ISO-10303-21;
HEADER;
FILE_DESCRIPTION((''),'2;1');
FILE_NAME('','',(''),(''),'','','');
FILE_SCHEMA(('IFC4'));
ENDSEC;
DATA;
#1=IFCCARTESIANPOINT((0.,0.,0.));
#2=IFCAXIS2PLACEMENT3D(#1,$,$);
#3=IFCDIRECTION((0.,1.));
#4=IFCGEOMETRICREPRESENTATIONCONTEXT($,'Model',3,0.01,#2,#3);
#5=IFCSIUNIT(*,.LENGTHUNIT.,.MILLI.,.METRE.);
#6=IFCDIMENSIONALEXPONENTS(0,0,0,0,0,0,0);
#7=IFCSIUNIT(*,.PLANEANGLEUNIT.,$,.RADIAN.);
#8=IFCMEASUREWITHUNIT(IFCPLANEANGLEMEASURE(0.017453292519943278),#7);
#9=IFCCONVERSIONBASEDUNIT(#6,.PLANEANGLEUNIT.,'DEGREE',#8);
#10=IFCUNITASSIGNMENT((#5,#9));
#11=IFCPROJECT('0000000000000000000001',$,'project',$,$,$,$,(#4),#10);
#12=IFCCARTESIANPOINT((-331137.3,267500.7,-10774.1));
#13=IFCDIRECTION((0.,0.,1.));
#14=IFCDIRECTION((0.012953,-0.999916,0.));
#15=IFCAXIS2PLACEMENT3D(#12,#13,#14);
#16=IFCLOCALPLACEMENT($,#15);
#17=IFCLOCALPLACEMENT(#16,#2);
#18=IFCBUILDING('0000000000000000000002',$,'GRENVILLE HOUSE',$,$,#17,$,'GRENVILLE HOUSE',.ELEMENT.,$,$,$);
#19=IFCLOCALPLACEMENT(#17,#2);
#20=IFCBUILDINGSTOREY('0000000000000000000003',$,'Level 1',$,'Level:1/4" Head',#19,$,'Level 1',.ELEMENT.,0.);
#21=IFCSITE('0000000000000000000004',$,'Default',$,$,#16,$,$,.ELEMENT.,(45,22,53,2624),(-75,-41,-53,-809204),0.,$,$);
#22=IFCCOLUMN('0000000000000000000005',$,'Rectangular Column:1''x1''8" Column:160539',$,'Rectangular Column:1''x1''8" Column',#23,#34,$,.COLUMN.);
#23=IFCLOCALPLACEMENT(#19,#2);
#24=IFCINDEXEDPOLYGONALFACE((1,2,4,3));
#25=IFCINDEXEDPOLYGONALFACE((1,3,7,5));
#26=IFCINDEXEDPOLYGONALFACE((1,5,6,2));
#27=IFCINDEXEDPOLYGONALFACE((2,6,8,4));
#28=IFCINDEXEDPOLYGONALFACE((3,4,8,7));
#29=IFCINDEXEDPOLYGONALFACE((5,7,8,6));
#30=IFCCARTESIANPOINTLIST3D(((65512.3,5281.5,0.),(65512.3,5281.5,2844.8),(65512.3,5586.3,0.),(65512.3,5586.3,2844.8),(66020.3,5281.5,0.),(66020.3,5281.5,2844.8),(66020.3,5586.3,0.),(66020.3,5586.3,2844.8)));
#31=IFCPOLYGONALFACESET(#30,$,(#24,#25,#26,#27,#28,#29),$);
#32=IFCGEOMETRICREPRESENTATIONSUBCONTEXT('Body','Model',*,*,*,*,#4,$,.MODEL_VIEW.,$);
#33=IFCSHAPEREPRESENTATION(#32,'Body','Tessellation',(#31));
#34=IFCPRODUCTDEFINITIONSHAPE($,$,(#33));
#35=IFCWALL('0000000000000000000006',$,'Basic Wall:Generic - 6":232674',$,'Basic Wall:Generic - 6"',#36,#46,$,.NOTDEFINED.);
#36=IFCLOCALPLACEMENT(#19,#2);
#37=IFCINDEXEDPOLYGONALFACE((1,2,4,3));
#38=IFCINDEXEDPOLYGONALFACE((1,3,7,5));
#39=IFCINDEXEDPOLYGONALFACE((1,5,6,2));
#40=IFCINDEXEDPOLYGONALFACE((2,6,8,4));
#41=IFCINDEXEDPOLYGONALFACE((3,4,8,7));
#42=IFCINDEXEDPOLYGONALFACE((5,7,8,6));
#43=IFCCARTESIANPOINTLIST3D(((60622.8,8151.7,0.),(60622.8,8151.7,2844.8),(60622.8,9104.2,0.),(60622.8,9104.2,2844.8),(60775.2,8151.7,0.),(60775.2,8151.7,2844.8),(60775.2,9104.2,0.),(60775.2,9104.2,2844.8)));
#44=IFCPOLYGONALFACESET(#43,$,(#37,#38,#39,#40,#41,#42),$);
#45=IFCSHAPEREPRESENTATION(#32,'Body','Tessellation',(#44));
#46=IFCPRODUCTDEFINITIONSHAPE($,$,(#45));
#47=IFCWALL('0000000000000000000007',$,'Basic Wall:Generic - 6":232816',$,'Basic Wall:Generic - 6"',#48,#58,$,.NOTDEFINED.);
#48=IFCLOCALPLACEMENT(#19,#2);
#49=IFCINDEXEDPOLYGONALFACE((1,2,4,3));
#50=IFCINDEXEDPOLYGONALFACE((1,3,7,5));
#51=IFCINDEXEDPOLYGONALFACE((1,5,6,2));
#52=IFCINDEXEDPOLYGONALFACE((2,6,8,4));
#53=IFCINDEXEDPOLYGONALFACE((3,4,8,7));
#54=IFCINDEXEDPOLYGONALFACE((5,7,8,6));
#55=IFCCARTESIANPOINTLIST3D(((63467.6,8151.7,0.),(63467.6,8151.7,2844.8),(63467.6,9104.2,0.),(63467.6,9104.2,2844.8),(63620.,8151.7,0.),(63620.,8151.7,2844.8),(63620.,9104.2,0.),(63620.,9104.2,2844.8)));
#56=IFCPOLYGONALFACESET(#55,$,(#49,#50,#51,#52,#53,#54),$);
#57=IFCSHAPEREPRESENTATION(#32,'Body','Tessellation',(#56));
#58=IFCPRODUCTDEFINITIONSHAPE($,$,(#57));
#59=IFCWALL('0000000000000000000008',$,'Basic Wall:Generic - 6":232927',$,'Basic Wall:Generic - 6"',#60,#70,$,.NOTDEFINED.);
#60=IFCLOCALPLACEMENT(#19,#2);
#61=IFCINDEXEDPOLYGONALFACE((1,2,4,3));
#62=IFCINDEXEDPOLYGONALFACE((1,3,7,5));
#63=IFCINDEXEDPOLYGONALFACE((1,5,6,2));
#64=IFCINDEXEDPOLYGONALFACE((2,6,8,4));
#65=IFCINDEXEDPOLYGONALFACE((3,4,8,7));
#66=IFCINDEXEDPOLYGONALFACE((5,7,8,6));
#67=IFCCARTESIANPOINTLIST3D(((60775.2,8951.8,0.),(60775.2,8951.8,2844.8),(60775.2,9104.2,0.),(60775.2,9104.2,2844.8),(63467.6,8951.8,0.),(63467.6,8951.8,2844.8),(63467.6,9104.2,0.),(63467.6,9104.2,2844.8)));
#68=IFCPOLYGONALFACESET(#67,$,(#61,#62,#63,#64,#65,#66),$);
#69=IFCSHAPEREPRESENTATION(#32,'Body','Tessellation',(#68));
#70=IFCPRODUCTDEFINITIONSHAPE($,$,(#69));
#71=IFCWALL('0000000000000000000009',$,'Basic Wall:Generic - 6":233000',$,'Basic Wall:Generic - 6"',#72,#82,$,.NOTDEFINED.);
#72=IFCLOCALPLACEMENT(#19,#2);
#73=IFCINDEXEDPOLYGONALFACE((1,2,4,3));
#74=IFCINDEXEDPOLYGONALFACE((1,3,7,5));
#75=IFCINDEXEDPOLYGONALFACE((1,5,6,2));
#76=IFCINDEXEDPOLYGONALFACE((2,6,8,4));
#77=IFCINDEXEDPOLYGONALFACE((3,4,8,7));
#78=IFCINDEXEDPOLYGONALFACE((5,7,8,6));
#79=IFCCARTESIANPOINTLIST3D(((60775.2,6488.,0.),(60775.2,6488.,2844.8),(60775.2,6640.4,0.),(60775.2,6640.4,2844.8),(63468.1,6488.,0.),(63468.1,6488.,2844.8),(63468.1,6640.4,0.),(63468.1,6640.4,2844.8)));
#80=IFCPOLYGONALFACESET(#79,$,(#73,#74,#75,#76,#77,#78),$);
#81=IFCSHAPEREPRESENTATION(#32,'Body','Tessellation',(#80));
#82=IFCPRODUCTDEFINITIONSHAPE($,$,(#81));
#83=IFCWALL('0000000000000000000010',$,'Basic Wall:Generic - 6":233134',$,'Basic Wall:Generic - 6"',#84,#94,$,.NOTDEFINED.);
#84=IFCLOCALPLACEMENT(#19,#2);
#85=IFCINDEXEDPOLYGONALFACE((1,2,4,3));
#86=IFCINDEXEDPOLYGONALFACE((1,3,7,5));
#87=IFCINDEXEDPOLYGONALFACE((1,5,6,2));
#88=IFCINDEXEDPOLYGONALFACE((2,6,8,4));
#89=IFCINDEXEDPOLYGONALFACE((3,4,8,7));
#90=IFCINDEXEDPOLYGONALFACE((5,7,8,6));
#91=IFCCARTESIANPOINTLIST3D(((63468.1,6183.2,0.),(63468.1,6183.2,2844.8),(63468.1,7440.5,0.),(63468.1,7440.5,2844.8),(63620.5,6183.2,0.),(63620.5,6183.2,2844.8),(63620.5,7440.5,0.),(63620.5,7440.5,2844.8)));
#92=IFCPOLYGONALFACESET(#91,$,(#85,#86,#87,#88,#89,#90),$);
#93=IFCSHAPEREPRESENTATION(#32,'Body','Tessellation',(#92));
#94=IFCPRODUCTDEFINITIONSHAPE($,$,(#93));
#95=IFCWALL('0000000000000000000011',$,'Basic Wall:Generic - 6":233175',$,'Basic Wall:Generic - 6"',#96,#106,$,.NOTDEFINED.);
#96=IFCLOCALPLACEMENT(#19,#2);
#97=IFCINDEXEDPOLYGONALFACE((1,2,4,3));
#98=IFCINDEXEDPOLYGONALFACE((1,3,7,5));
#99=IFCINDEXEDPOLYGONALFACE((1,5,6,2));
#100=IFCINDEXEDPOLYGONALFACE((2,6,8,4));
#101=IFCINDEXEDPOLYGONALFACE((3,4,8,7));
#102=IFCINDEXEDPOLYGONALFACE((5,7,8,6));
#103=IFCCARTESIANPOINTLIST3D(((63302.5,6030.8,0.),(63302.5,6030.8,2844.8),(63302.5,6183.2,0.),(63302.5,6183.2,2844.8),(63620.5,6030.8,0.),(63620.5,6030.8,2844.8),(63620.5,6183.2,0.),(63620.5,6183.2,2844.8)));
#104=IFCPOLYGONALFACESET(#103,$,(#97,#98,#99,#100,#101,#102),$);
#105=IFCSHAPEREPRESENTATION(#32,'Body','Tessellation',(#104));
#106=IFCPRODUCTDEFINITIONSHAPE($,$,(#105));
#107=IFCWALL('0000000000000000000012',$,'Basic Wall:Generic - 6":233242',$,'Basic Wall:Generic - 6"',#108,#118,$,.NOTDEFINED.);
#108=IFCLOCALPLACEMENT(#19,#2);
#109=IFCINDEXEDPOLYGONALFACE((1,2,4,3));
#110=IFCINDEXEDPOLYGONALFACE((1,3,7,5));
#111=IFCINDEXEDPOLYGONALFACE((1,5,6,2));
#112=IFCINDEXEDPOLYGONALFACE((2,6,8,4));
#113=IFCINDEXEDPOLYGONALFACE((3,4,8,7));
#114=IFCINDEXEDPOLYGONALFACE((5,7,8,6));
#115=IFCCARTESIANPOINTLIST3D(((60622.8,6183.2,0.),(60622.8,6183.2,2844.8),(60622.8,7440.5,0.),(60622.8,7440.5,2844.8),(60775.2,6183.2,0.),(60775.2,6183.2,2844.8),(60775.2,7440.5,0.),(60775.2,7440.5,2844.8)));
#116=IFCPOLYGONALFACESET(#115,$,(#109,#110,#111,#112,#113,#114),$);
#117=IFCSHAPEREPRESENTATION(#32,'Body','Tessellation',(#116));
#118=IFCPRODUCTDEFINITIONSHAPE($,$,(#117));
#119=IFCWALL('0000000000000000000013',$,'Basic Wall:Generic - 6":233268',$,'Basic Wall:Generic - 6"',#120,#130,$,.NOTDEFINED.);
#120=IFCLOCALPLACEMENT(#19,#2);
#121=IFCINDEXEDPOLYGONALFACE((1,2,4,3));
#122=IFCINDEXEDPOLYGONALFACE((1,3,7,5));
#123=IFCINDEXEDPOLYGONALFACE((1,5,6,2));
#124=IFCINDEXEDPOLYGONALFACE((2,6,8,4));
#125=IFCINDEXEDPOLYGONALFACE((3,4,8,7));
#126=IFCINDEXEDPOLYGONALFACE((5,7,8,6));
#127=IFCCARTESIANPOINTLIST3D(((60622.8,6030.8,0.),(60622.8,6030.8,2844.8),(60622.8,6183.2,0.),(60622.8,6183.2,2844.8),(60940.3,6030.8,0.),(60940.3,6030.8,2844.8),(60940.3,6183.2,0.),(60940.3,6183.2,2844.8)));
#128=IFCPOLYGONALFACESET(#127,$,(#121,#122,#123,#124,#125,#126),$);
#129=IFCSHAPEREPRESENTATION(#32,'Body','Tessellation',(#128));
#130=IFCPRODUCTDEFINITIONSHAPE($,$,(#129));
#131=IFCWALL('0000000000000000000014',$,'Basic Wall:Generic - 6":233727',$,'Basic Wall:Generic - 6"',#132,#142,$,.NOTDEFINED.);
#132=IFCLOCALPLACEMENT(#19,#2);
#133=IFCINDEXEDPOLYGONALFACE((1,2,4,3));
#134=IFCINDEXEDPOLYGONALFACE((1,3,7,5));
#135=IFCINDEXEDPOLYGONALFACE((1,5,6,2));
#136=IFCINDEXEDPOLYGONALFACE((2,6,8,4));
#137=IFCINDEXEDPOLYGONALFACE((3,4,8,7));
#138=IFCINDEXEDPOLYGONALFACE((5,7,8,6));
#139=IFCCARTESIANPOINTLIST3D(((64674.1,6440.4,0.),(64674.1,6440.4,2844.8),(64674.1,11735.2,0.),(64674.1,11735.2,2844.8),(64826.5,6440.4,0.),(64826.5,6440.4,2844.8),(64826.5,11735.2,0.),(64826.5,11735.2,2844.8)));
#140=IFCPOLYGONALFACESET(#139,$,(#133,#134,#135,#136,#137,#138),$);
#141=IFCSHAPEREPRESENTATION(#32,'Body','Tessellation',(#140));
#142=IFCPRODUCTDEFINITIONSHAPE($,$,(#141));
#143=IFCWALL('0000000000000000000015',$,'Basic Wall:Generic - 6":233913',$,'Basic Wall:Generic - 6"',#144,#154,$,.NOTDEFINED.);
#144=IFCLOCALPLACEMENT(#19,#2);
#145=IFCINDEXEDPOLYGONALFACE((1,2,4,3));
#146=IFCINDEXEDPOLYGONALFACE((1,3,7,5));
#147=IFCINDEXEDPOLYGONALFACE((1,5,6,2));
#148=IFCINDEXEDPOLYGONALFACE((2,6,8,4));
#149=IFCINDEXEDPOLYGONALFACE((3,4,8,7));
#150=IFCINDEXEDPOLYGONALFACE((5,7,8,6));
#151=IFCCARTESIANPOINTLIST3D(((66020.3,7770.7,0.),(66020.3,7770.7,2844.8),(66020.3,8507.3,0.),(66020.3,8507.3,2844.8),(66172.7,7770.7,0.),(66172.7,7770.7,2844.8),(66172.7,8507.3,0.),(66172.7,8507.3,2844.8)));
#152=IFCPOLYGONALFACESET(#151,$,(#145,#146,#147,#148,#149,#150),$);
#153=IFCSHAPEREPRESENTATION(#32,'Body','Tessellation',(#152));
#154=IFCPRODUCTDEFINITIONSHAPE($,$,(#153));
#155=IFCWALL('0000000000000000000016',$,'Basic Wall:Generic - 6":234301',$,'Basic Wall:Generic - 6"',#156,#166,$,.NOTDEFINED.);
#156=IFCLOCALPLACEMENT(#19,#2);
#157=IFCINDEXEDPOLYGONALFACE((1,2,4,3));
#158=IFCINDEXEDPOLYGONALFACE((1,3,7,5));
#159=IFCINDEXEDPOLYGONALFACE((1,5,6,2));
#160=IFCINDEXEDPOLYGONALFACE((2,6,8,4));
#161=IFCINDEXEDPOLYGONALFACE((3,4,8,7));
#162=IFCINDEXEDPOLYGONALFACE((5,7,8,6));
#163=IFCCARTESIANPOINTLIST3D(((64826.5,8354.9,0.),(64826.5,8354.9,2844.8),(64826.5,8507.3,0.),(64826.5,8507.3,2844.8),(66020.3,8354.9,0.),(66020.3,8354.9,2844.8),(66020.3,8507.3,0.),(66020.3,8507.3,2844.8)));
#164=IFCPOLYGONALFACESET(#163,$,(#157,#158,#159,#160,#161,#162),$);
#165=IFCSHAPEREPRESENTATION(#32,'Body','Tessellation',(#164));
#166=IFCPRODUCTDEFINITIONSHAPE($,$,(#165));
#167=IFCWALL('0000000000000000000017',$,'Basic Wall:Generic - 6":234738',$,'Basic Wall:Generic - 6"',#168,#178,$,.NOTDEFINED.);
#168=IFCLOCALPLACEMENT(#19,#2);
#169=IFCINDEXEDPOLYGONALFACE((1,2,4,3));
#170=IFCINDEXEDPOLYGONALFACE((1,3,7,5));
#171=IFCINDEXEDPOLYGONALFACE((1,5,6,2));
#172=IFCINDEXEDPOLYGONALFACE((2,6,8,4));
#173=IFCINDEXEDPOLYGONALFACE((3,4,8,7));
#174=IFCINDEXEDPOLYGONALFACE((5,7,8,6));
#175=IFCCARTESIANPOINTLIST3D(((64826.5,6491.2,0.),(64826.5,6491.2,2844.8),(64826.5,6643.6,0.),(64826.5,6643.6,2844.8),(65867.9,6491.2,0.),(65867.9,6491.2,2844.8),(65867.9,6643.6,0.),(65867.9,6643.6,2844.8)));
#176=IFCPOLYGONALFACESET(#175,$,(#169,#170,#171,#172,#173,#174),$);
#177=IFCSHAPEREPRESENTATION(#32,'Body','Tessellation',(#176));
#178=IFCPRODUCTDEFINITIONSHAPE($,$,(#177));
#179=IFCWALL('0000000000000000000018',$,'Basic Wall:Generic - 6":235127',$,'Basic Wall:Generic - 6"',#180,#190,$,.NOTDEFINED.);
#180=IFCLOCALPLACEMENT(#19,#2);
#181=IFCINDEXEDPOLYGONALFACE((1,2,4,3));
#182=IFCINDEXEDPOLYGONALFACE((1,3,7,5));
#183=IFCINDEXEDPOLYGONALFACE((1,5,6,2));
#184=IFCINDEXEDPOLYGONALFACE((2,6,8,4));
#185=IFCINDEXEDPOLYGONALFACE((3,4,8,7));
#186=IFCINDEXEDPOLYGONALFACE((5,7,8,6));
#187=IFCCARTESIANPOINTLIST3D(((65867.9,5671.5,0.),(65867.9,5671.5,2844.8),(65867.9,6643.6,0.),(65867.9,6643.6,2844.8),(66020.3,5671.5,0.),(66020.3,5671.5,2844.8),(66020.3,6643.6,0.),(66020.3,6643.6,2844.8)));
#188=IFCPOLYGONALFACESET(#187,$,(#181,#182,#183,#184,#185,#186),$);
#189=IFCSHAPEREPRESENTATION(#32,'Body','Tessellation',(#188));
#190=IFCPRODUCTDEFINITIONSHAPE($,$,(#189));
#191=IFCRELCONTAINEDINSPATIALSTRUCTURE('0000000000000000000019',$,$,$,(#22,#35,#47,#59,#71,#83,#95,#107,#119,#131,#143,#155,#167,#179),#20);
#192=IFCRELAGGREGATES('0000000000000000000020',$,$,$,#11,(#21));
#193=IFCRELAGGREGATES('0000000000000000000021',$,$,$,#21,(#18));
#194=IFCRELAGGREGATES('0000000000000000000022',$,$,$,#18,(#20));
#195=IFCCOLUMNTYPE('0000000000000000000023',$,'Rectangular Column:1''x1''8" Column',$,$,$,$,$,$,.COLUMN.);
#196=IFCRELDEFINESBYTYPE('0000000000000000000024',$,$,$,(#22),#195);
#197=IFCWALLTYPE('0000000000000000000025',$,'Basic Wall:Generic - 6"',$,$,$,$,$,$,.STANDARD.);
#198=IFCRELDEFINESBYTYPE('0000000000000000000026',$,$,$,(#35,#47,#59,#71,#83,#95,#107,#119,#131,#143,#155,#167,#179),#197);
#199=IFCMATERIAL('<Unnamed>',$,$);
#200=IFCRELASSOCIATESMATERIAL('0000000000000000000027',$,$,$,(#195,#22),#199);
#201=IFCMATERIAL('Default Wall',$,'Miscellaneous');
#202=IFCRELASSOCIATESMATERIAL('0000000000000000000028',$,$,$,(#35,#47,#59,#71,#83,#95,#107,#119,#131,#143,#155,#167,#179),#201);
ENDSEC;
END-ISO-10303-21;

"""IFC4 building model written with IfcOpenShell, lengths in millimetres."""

from ifc_helpers import new_model, entity, si_unit, converted_unit, direction, frame, origin, place, context, subcontext, project, spatial, indexed_curve, outline, extrude, source, transform, mapped, material, type_object, type_shapes, element, save


model = new_model("IFC4")

# Units and contexts
model_context = context("Model", 3, precision=0.01, world=origin(), true_north=direction((0.0, 1.0)))
body_context = subcontext(model_context, "Body", "Model", "MODEL_VIEW")
ifc_project = project(units=[si_unit("LENGTHUNIT", "METRE", prefix="MILLI"), converted_unit("PLANEANGLEUNIT", "DEGREE", entity("IfcPlaneAngleMeasure", 0.017453292519943278), si_unit("PLANEANGLEUNIT", "RADIAN"), dimensions=[0, 0, 0, 0, 0, 0, 0])], contexts=[model_context])

# Site, building, storey
site_placement = place(None, frame((-331137.3, 267500.7, -10774.1), z_axis=(0.0, 0.0, 1.0), x_axis=(0.012953, -0.999916, 0.0)))
site = spatial("IfcSite", under=ifc_project, at=site_placement, Name="Default", CompositionType="ELEMENT", RefLatitude=(45, 22, 53, 2624), RefLongitude=(-75, -41, -53, -809204), RefElevation=0.0)
building_placement = place(site_placement, origin())
building = spatial("IfcBuilding", under=site, at=building_placement, Name="GRENVILLE HOUSE", LongName="GRENVILLE HOUSE", CompositionType="ELEMENT")
storey_placement = place(building_placement, origin())
storey = spatial("IfcBuildingStorey", under=building, at=storey_placement, Name="Level 1", ObjectType="Level:1/4\" Head", LongName="Level 1", CompositionType="ELEMENT", Elevation=0.0)

# Column
ifc_material_1 = material(Name="<Unnamed>")
column_type = type_object("IfcColumnType", Name="Rectangular Column:1'x1'8\" Column", PredefinedType="COLUMN", material=ifc_material_1)
shared_shape = source(origin(), body_context, "Body", "SweptSolid", [
    extrude(outline(indexed_curve([(-254.0, -152.4), (254.0, -152.4), (254.0, 152.4), (-254.0, 152.4), (-254.0, -152.4)], self_intersect=False)), frame((0.0, 0.0, 0.0), z_axis=(0.0, 0.0, 1.0), x_axis=(-1.0, 0.0, 0.0)), (0.0, 0.0, 1.0), 2844.8),
])
type_shapes(column_type, [shared_shape])
column_placement = place(storey_placement, frame((65766.3, 5433.9, 0.0)))
element("IfcColumn", 1, at=column_placement, inside=storey, type_object=column_type, material=ifc_material_1, Name="Rectangular Column:1'x1'8\" Column:160539", ObjectType="Rectangular Column:1'x1'8\" Column", PredefinedType="COLUMN", context=body_context, shape_type="MappedRepresentation", body=[
    mapped(shared_shape, transform((0.0, 0.0, 0.0), scale=1.0)),
])

# Walls
ifc_material_2 = material(Name="Default Wall", Category="Miscellaneous")
wall_type = type_object("IfcWallType", Name="Basic Wall:Generic - 6\"", PredefinedType="STANDARD")
wall_1_placement = place(storey_placement, frame((60699.0, 8151.7, 0.0), z_axis=(0.0, 0.0, 1.0), x_axis=(0.0, 1.0, 0.0)))
element("IfcWall", 2, at=wall_1_placement, inside=storey, type_object=wall_type, material=ifc_material_2, Name="Basic Wall:Generic - 6\":232674", ObjectType="Basic Wall:Generic - 6\"", PredefinedType="NOTDEFINED", context=body_context, shape_type="SweptSolid", body=[
    extrude(outline(indexed_curve([(952.5, 76.2), (0.0, 76.2), (0.0, -76.2), (952.5, -76.2), (952.5, 76.2)], self_intersect=False)), origin(), (0.0, 0.0, 1.0), 2844.8),
])
wall_2_placement = place(storey_placement, frame((63543.8, 9104.2, 0.0), z_axis=(0.0, 0.0, 1.0), x_axis=(0.0, -1.0, 0.0)))
element("IfcWall", 3, at=wall_2_placement, inside=storey, type_object=wall_type, material=ifc_material_2, Name="Basic Wall:Generic - 6\":232816", ObjectType="Basic Wall:Generic - 6\"", PredefinedType="NOTDEFINED", context=body_context, shape_type="SweptSolid", body=[
    extrude(outline(indexed_curve([(952.5, 76.2), (0.0, 76.2), (0.0, -76.2), (952.5, -76.2), (952.5, 76.2)], self_intersect=False)), origin(), (0.0, 0.0, 1.0), 2844.8),
])
wall_3_placement = place(storey_placement, frame((60775.2, 9028.0, 0.0)))
element("IfcWall", 4, at=wall_3_placement, inside=storey, type_object=wall_type, material=ifc_material_2, Name="Basic Wall:Generic - 6\":232927", ObjectType="Basic Wall:Generic - 6\"", PredefinedType="NOTDEFINED", context=body_context, shape_type="SweptSolid", body=[
    extrude(outline(indexed_curve([(2692.4, 76.2), (0.0, 76.2), (0.0, -76.2), (2692.4, -76.2), (2692.4, 76.2)], self_intersect=False)), origin(), (0.0, 0.0, 1.0), 2844.8),
])
wall_4_placement = place(storey_placement, frame((60775.2, 6564.2, 0.0)))
element("IfcWall", 5, at=wall_4_placement, inside=storey, type_object=wall_type, material=ifc_material_2, Name="Basic Wall:Generic - 6\":233000", ObjectType="Basic Wall:Generic - 6\"", PredefinedType="NOTDEFINED", context=body_context, shape_type="SweptSolid", body=[
    extrude(outline(indexed_curve([(2692.9, 76.2), (0.0, 76.2), (0.0, -76.2), (2692.9, -76.2), (2692.9, 76.2)], self_intersect=False)), origin(), (0.0, 0.0, 1.0), 2844.8),
])
wall_5_placement = place(storey_placement, frame((63544.3, 7440.5, 0.0), z_axis=(0.0, 0.0, 1.0), x_axis=(0.0, -1.0, 0.0)))
element("IfcWall", 6, at=wall_5_placement, inside=storey, type_object=wall_type, material=ifc_material_2, Name="Basic Wall:Generic - 6\":233134", ObjectType="Basic Wall:Generic - 6\"", PredefinedType="NOTDEFINED", context=body_context, shape_type="SweptSolid", body=[
    extrude(outline(indexed_curve([(1257.3, 76.2), (0.0, 76.2), (0.0, -76.2), (1257.3, -76.2), (1257.3, 76.2)], self_intersect=False)), origin(), (0.0, 0.0, 1.0), 2844.8),
])
wall_6_placement = place(storey_placement, frame((63620.5, 6107.0, 0.0), z_axis=(0.0, 0.0, 1.0), x_axis=(-1.0, 0.0, 0.0)))
element("IfcWall", 7, at=wall_6_placement, inside=storey, type_object=wall_type, material=ifc_material_2, Name="Basic Wall:Generic - 6\":233175", ObjectType="Basic Wall:Generic - 6\"", PredefinedType="NOTDEFINED", context=body_context, shape_type="SweptSolid", body=[
    extrude(outline(indexed_curve([(318.0, 76.2), (0.0, 76.2), (0.0, -76.2), (318.0, -76.2), (318.0, 76.2)], self_intersect=False)), origin(), (0.0, 0.0, 1.0), 2844.8),
])
wall_7_placement = place(storey_placement, frame((60699.0, 7440.5, 0.0), z_axis=(0.0, 0.0, 1.0), x_axis=(0.0, -1.0, 0.0)))
element("IfcWall", 8, at=wall_7_placement, inside=storey, type_object=wall_type, material=ifc_material_2, Name="Basic Wall:Generic - 6\":233242", ObjectType="Basic Wall:Generic - 6\"", PredefinedType="NOTDEFINED", context=body_context, shape_type="SweptSolid", body=[
    extrude(outline(indexed_curve([(1257.3, 76.2), (0.0, 76.2), (0.0, -76.2), (1257.3, -76.2), (1257.3, 76.2)], self_intersect=False)), origin(), (0.0, 0.0, 1.0), 2844.8),
])
wall_8_placement = place(storey_placement, frame((60622.8, 6107.0, 0.0)))
element("IfcWall", 9, at=wall_8_placement, inside=storey, type_object=wall_type, material=ifc_material_2, Name="Basic Wall:Generic - 6\":233268", ObjectType="Basic Wall:Generic - 6\"", PredefinedType="NOTDEFINED", context=body_context, shape_type="SweptSolid", body=[
    extrude(outline(indexed_curve([(317.5, 76.2), (0.0, 76.2), (0.0, -76.2), (317.5, -76.2), (317.5, 76.2)], self_intersect=False)), origin(), (0.0, 0.0, 1.0), 2844.8),
])
wall_9_placement = place(storey_placement, frame((64750.3, 11735.2, 0.0), z_axis=(0.0, 0.0, 1.0), x_axis=(0.0, -1.0, 0.0)))
element("IfcWall", 10, at=wall_9_placement, inside=storey, type_object=wall_type, material=ifc_material_2, Name="Basic Wall:Generic - 6\":233727", ObjectType="Basic Wall:Generic - 6\"", PredefinedType="NOTDEFINED", context=body_context, shape_type="SweptSolid", body=[
    extrude(outline(indexed_curve([(5294.7, 76.2), (0.0, 76.2), (0.0, -76.2), (5294.7, -76.2), (5294.7, 76.2)], self_intersect=False)), origin(), (0.0, 0.0, 1.0), 2844.8),
])
wall_10_placement = place(storey_placement, frame((66096.5, 8507.3, 0.0), z_axis=(0.0, 0.0, 1.0), x_axis=(0.0, -1.0, 0.0)))
element("IfcWall", 11, at=wall_10_placement, inside=storey, type_object=wall_type, material=ifc_material_2, Name="Basic Wall:Generic - 6\":233913", ObjectType="Basic Wall:Generic - 6\"", PredefinedType="NOTDEFINED", context=body_context, shape_type="SweptSolid", body=[
    extrude(outline(indexed_curve([(736.6, 76.2), (0.0, 76.2), (0.0, -76.2), (736.6, -76.2), (736.6, 76.2)], self_intersect=False)), origin(), (0.0, 0.0, 1.0), 2844.8),
])
wall_11_placement = place(storey_placement, frame((66020.3, 8431.1, 0.0), z_axis=(0.0, 0.0, 1.0), x_axis=(-1.0, 0.0, 0.0)))
element("IfcWall", 12, at=wall_11_placement, inside=storey, type_object=wall_type, material=ifc_material_2, Name="Basic Wall:Generic - 6\":234301", ObjectType="Basic Wall:Generic - 6\"", PredefinedType="NOTDEFINED", context=body_context, shape_type="SweptSolid", body=[
    extrude(outline(indexed_curve([(1193.8, 76.2), (0.0, 76.2), (0.0, -76.2), (1193.8, -76.2), (1193.8, 76.2)], self_intersect=False)), origin(), (0.0, 0.0, 1.0), 2844.8),
])
wall_12_placement = place(storey_placement, frame((64826.5, 6567.4, 0.0)))
element("IfcWall", 13, at=wall_12_placement, inside=storey, type_object=wall_type, material=ifc_material_2, Name="Basic Wall:Generic - 6\":234738", ObjectType="Basic Wall:Generic - 6\"", PredefinedType="NOTDEFINED", context=body_context, shape_type="SweptSolid", body=[
    extrude(outline(indexed_curve([(1041.4, 76.2), (0.0, 76.2), (0.0, -76.2), (1041.4, -76.2), (1041.4, 76.2)], self_intersect=False)), origin(), (0.0, 0.0, 1.0), 2844.8),
])
wall_13_placement = place(storey_placement, frame((65944.1, 6643.6, 0.0), z_axis=(0.0, 0.0, 1.0), x_axis=(0.0, -1.0, 0.0)))
element("IfcWall", 14, at=wall_13_placement, inside=storey, type_object=wall_type, material=ifc_material_2, Name="Basic Wall:Generic - 6\":235127", ObjectType="Basic Wall:Generic - 6\"", PredefinedType="NOTDEFINED", context=body_context, shape_type="SweptSolid", body=[
    extrude(outline(indexed_curve([(972.1, 76.2), (0.0, 76.2), (0.0, -76.2), (972.1, -76.2), (972.1, 76.2)], self_intersect=False)), origin(), (0.0, 0.0, 1.0), 2844.8),
])

save(model, "model.ifc")
